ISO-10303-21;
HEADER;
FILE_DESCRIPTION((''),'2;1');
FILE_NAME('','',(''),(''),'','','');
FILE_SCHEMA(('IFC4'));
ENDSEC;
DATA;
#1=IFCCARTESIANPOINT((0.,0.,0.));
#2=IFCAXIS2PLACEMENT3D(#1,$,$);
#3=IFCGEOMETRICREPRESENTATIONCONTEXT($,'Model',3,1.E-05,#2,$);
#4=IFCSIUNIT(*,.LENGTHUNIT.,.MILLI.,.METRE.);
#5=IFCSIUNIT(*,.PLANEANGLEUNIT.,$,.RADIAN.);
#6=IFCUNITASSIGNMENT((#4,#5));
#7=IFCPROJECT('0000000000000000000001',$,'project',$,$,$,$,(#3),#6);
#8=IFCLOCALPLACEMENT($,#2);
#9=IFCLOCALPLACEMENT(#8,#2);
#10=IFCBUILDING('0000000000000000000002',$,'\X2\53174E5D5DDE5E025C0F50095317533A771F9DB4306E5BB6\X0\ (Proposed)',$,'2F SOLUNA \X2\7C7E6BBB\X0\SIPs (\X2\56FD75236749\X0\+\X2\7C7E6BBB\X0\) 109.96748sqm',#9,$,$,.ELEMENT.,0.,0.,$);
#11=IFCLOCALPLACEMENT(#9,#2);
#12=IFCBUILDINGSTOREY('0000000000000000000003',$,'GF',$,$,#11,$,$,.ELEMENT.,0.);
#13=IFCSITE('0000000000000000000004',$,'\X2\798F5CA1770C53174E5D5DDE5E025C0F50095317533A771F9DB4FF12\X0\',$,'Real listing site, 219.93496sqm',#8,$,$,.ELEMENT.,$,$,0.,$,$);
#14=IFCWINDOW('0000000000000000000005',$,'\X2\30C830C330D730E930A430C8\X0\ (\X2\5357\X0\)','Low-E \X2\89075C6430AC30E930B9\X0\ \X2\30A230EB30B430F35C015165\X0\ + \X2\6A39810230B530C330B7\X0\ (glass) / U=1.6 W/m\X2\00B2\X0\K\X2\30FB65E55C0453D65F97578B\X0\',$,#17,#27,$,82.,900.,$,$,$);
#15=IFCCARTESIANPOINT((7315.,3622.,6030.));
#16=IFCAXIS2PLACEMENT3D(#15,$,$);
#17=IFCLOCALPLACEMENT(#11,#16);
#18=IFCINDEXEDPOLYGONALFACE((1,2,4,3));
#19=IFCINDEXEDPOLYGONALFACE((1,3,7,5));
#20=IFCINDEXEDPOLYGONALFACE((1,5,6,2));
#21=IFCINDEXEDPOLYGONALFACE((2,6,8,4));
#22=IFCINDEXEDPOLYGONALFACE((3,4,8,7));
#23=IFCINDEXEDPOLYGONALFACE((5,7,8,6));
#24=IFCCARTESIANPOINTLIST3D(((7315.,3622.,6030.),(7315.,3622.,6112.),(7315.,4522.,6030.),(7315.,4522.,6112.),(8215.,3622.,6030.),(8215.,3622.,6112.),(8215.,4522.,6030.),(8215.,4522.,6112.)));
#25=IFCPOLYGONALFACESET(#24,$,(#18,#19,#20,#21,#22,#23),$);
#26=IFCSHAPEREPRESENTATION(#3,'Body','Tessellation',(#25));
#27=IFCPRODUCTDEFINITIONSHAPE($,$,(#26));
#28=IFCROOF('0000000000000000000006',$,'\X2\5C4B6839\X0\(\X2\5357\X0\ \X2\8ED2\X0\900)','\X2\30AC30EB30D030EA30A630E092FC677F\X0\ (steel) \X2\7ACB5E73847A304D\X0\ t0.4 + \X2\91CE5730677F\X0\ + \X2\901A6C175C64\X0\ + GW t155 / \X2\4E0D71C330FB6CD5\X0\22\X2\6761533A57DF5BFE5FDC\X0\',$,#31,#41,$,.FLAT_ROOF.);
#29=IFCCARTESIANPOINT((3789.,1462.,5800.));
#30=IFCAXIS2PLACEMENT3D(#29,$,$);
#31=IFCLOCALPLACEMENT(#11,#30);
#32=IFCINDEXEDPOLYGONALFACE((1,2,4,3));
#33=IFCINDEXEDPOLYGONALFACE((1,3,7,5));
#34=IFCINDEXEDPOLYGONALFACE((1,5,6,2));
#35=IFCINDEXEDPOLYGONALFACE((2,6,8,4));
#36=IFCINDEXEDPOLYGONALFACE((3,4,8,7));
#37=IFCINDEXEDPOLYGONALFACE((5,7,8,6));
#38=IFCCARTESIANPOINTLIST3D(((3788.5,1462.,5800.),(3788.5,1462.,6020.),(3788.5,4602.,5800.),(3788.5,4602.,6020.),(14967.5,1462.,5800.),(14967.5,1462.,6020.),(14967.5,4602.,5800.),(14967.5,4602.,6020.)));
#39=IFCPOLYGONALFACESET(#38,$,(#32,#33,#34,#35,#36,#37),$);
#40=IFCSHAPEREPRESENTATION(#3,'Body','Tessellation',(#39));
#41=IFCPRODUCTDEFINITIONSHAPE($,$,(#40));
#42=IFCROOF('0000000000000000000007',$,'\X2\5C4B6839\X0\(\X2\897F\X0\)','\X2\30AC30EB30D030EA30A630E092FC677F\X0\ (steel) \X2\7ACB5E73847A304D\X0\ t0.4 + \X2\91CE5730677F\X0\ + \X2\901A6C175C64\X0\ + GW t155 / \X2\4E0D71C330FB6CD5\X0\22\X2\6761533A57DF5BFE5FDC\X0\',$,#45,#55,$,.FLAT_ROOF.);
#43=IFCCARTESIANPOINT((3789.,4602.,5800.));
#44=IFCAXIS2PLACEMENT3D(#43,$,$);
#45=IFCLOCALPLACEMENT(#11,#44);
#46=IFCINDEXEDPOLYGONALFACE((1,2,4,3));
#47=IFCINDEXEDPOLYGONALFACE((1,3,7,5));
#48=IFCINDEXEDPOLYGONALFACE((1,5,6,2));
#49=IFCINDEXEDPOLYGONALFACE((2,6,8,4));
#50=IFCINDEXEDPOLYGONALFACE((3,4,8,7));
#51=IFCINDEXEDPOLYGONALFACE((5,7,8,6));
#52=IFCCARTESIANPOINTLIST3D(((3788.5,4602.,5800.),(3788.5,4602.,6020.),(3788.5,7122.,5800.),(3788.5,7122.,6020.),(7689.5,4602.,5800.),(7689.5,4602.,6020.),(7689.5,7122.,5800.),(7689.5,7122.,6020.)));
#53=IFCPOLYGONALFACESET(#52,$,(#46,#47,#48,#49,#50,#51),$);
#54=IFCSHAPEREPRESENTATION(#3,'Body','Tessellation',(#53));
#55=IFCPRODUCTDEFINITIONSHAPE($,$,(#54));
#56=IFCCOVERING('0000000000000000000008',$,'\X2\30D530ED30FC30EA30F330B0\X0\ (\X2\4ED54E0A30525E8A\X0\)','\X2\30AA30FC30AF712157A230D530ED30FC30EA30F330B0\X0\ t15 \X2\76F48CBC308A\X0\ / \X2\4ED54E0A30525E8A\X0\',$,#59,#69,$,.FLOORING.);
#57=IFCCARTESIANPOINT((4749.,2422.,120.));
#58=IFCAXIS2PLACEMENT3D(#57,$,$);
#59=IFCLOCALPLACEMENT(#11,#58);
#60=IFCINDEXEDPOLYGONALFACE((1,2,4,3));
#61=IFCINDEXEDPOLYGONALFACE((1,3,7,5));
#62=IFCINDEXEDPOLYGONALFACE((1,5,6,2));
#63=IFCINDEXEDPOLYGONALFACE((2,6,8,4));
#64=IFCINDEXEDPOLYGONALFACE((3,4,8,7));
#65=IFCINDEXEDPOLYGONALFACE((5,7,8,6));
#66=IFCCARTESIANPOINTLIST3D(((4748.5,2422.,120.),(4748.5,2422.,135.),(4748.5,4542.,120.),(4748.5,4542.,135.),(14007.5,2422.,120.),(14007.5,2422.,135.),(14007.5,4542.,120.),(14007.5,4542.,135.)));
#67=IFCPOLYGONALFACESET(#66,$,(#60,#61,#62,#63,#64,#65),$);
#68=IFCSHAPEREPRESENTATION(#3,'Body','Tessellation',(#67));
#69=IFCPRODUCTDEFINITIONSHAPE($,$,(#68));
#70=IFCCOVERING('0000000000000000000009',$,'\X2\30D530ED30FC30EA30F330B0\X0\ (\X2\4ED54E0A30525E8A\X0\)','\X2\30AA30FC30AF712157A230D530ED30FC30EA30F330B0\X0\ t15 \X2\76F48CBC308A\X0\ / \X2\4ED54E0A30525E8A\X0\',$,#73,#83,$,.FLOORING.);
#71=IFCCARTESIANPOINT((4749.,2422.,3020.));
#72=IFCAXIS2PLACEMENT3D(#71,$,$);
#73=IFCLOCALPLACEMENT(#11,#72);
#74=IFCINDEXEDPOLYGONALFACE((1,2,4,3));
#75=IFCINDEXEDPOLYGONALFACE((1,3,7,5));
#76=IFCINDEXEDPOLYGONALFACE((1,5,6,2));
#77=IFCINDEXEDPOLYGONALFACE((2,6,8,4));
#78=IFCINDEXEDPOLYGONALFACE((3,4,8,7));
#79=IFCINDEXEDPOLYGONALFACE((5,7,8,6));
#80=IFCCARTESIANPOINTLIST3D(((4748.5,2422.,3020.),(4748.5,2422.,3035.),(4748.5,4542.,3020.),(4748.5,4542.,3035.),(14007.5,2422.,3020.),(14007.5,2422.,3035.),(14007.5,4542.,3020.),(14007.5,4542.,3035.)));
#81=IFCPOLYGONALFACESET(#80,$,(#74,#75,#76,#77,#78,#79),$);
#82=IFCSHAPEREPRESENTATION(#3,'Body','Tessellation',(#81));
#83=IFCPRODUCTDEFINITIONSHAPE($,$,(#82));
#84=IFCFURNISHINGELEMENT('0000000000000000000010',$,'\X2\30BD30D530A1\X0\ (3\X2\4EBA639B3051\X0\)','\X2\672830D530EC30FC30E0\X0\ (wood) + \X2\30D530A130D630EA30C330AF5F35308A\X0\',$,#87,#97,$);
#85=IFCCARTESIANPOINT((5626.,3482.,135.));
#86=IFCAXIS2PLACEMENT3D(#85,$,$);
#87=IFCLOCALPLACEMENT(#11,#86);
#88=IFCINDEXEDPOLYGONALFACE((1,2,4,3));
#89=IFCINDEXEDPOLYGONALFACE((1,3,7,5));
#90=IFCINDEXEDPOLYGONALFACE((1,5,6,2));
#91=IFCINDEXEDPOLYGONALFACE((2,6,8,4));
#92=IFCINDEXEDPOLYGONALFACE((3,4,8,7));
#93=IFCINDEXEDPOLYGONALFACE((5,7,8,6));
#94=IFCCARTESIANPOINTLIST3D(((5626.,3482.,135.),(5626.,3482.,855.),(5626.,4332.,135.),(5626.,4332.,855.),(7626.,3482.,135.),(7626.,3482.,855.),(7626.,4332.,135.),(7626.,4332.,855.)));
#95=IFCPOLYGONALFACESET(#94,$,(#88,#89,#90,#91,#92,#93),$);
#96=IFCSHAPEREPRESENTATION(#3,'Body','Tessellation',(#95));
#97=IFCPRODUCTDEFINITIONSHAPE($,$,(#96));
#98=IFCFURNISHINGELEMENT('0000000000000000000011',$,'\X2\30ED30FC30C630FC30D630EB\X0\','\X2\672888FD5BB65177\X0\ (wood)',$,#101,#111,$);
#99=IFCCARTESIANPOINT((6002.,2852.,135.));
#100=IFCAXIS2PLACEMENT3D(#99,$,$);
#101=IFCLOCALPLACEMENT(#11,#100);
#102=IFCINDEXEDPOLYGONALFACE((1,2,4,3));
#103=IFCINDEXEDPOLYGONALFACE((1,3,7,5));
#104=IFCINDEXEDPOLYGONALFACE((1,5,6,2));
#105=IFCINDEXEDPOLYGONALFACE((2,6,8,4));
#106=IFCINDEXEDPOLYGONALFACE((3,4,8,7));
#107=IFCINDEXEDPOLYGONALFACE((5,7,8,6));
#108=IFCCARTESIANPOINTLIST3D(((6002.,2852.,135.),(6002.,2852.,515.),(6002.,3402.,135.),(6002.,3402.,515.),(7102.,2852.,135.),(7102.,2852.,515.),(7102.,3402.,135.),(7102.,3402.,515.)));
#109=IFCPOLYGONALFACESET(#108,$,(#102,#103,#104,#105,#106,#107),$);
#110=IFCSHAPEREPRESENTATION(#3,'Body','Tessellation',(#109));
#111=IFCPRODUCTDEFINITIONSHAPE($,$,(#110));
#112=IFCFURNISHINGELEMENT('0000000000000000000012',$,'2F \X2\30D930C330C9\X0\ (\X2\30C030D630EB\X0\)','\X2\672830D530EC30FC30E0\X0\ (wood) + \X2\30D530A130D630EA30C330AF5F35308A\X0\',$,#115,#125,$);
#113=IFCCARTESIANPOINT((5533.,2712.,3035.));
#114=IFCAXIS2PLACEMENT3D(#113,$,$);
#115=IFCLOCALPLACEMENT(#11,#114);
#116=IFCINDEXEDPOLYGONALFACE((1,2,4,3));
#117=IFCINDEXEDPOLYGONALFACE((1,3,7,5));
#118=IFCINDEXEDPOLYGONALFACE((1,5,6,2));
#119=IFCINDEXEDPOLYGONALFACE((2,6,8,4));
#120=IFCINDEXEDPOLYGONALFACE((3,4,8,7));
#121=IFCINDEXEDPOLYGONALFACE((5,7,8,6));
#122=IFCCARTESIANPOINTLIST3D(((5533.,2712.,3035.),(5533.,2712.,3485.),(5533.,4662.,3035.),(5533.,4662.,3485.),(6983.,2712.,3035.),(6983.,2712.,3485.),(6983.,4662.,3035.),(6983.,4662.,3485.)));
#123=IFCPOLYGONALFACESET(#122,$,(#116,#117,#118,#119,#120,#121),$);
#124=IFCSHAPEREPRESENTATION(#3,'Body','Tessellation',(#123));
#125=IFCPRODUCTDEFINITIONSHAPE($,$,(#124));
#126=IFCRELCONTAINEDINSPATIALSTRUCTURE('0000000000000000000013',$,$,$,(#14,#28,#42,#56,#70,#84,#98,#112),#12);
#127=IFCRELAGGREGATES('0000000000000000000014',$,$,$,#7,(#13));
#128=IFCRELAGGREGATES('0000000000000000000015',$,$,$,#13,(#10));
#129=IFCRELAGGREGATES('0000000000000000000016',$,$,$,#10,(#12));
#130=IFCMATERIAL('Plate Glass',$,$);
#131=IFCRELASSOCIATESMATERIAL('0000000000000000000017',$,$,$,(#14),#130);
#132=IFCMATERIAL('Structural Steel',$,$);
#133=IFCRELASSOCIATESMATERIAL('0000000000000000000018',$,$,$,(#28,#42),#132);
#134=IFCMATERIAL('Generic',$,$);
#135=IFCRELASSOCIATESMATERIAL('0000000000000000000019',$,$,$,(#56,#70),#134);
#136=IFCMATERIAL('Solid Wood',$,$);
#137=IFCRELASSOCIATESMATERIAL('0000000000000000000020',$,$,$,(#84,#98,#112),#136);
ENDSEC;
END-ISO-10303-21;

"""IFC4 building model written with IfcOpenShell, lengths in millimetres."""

from ifc_helpers import new_model, si_unit, frame, frame_2d, origin, place, context, project, spatial, rectangle, extrude, material, element, save


model = new_model("IFC4")

# Units and contexts
model_context = context("Model", 3, precision=1e-05, world=origin())
ifc_project = project(units=[si_unit("LENGTHUNIT", "METRE", prefix="MILLI"), si_unit("PLANEANGLEUNIT", "RADIAN")], contexts=[model_context])

# Site, building, storey
site_placement = place(None, origin())
site = spatial("IfcSite", under=ifc_project, at=site_placement, Name="福岡県北九州市小倉北区真鶴２", ObjectType="Real listing site, 219.93496sqm", CompositionType="ELEMENT", RefElevation=0.0)
building_placement = place(site_placement, origin())
building = spatial("IfcBuilding", under=site, at=building_placement, Name="北九州市小倉北区真鶴の家 (Proposed)", ObjectType="2F SOLUNA 籾殻SIPs (国産杉+籾殻) 109.96748sqm", CompositionType="ELEMENT", ElevationOfRefHeight=0.0, ElevationOfTerrain=0.0)
storey_placement = place(building_placement, origin())
storey = spatial("IfcBuildingStorey", under=building, at=storey_placement, Name="GF", CompositionType="ELEMENT", Elevation=0.0)

# Shared definitions
ifc_material_1 = material(Name="Solid Wood")

# Shared definitions
ifc_material_2 = material(Name="Plate Glass")

# Window
window_1_placement = place(storey_placement, frame((7315.0, 3622.0, 6030.0)))
element("IfcWindow", 1, at=window_1_placement, inside=storey, material=ifc_material_2, Name="トップライト (南)", Description="Low-E 複層ガラス アルゴン封入 + 樹脂サッシ (glass) / U=1.6 W/m²K・日射取得型", OverallHeight=82.0, OverallWidth=900.0, context=model_context, shape_type="SweptSolid", body=[
    extrude(rectangle(XDim=900.0, YDim=900.0, at=frame_2d((450.0, 450.0))), frame((7315.0, 3622.0, 6030.0)), (0.0, 0.0, 1.0), 82.0),
])

# Roofs
ifc_material_3 = material(Name="Structural Steel")
roof_1_placement = place(storey_placement, frame((3789.0, 1462.0, 5800.0)))
element("IfcRoof", 2, at=roof_1_placement, inside=storey, material=ifc_material_3, Name="屋根(南 軒900)", Description="ガルバリウム鋼板 (steel) 立平葺き t0.4 + 野地板 + 通気層 + GW t155 / 不燃・法22条区域対応", PredefinedType="FLAT_ROOF", context=model_context, shape_type="SweptSolid", body=[
    extrude(rectangle(XDim=11179.0, YDim=3140.0, at=frame_2d((5589.0, 1570.0))), frame((3789.0, 1462.0, 5800.0)), (0.0, 0.0, 1.0), 220.0),
])
roof_2_placement = place(storey_placement, frame((3789.0, 4602.0, 5800.0)))
element("IfcRoof", 3, at=roof_2_placement, inside=storey, material=ifc_material_3, Name="屋根(西)", Description="ガルバリウム鋼板 (steel) 立平葺き t0.4 + 野地板 + 通気層 + GW t155 / 不燃・法22条区域対応", PredefinedType="FLAT_ROOF", context=model_context, shape_type="SweptSolid", body=[
    extrude(rectangle(XDim=3901.0, YDim=2520.0, at=frame_2d((1950.0, 1260.0))), frame((3789.0, 4602.0, 5800.0)), (0.0, 0.0, 1.0), 220.0),
])

# Coverings
ifc_material_4 = material(Name="Generic")
covering_1_placement = place(storey_placement, frame((4749.0, 2422.0, 120.0)))
element("IfcCovering", 4, at=covering_1_placement, inside=storey, material=ifc_material_4, Name="フローリング (仕上げ床)", Description="オーク無垢フローリング t15 直貼り / 仕上げ床", PredefinedType="FLOORING", context=model_context, shape_type="SweptSolid", body=[
    extrude(rectangle(XDim=9259.0, YDim=2120.0, at=frame_2d((4629.0, 1060.0))), frame((4749.0, 2422.0, 120.0)), (0.0, 0.0, 1.0), 15.0),
])
covering_2_placement = place(storey_placement, frame((4749.0, 2422.0, 3020.0)))
element("IfcCovering", 5, at=covering_2_placement, inside=storey, material=ifc_material_4, Name="フローリング (仕上げ床)", Description="オーク無垢フローリング t15 直貼り / 仕上げ床", PredefinedType="FLOORING", context=model_context, shape_type="SweptSolid", body=[
    extrude(rectangle(XDim=9259.0, YDim=2120.0, at=frame_2d((4629.0, 1060.0))), frame((4749.0, 2422.0, 3020.0)), (0.0, 0.0, 1.0), 15.0),
])

# Furnishing elements
furnishing_1_placement = place(storey_placement, frame((5626.0, 3482.0, 135.0)))
element("IfcFurnishingElement", 6, at=furnishing_1_placement, inside=storey, material=ifc_material_1, Name="ソファ (3人掛け)", Description="木フレーム (wood) + ファブリック張り", context=model_context, shape_type="SweptSolid", body=[
    extrude(rectangle(XDim=2000.0, YDim=850.0, at=frame_2d((1000.0, 425.0))), frame((5626.0, 3482.0, 135.0)), (0.0, 0.0, 1.0), 720.0),
])
furnishing_2_placement = place(storey_placement, frame((6002.0, 2852.0, 135.0)))
element("IfcFurnishingElement", 7, at=furnishing_2_placement, inside=storey, material=ifc_material_1, Name="ローテーブル", Description="木製家具 (wood)", context=model_context, shape_type="SweptSolid", body=[
    extrude(rectangle(XDim=1100.0, YDim=550.0, at=frame_2d((550.0, 275.0))), frame((6002.0, 2852.0, 135.0)), (0.0, 0.0, 1.0), 380.0),
])
furnishing_3_placement = place(storey_placement, frame((5533.0, 2712.0, 3035.0)))
element("IfcFurnishingElement", 8, at=furnishing_3_placement, inside=storey, material=ifc_material_1, Name="2F ベッド (ダブル)", Description="木フレーム (wood) + ファブリック張り", context=model_context, shape_type="SweptSolid", body=[
    extrude(rectangle(XDim=1450.0, YDim=1950.0, at=frame_2d((725.0, 975.0))), frame((5533.0, 2712.0, 3035.0)), (0.0, 0.0, 1.0), 450.0),
])

save(model, "model.ifc")
